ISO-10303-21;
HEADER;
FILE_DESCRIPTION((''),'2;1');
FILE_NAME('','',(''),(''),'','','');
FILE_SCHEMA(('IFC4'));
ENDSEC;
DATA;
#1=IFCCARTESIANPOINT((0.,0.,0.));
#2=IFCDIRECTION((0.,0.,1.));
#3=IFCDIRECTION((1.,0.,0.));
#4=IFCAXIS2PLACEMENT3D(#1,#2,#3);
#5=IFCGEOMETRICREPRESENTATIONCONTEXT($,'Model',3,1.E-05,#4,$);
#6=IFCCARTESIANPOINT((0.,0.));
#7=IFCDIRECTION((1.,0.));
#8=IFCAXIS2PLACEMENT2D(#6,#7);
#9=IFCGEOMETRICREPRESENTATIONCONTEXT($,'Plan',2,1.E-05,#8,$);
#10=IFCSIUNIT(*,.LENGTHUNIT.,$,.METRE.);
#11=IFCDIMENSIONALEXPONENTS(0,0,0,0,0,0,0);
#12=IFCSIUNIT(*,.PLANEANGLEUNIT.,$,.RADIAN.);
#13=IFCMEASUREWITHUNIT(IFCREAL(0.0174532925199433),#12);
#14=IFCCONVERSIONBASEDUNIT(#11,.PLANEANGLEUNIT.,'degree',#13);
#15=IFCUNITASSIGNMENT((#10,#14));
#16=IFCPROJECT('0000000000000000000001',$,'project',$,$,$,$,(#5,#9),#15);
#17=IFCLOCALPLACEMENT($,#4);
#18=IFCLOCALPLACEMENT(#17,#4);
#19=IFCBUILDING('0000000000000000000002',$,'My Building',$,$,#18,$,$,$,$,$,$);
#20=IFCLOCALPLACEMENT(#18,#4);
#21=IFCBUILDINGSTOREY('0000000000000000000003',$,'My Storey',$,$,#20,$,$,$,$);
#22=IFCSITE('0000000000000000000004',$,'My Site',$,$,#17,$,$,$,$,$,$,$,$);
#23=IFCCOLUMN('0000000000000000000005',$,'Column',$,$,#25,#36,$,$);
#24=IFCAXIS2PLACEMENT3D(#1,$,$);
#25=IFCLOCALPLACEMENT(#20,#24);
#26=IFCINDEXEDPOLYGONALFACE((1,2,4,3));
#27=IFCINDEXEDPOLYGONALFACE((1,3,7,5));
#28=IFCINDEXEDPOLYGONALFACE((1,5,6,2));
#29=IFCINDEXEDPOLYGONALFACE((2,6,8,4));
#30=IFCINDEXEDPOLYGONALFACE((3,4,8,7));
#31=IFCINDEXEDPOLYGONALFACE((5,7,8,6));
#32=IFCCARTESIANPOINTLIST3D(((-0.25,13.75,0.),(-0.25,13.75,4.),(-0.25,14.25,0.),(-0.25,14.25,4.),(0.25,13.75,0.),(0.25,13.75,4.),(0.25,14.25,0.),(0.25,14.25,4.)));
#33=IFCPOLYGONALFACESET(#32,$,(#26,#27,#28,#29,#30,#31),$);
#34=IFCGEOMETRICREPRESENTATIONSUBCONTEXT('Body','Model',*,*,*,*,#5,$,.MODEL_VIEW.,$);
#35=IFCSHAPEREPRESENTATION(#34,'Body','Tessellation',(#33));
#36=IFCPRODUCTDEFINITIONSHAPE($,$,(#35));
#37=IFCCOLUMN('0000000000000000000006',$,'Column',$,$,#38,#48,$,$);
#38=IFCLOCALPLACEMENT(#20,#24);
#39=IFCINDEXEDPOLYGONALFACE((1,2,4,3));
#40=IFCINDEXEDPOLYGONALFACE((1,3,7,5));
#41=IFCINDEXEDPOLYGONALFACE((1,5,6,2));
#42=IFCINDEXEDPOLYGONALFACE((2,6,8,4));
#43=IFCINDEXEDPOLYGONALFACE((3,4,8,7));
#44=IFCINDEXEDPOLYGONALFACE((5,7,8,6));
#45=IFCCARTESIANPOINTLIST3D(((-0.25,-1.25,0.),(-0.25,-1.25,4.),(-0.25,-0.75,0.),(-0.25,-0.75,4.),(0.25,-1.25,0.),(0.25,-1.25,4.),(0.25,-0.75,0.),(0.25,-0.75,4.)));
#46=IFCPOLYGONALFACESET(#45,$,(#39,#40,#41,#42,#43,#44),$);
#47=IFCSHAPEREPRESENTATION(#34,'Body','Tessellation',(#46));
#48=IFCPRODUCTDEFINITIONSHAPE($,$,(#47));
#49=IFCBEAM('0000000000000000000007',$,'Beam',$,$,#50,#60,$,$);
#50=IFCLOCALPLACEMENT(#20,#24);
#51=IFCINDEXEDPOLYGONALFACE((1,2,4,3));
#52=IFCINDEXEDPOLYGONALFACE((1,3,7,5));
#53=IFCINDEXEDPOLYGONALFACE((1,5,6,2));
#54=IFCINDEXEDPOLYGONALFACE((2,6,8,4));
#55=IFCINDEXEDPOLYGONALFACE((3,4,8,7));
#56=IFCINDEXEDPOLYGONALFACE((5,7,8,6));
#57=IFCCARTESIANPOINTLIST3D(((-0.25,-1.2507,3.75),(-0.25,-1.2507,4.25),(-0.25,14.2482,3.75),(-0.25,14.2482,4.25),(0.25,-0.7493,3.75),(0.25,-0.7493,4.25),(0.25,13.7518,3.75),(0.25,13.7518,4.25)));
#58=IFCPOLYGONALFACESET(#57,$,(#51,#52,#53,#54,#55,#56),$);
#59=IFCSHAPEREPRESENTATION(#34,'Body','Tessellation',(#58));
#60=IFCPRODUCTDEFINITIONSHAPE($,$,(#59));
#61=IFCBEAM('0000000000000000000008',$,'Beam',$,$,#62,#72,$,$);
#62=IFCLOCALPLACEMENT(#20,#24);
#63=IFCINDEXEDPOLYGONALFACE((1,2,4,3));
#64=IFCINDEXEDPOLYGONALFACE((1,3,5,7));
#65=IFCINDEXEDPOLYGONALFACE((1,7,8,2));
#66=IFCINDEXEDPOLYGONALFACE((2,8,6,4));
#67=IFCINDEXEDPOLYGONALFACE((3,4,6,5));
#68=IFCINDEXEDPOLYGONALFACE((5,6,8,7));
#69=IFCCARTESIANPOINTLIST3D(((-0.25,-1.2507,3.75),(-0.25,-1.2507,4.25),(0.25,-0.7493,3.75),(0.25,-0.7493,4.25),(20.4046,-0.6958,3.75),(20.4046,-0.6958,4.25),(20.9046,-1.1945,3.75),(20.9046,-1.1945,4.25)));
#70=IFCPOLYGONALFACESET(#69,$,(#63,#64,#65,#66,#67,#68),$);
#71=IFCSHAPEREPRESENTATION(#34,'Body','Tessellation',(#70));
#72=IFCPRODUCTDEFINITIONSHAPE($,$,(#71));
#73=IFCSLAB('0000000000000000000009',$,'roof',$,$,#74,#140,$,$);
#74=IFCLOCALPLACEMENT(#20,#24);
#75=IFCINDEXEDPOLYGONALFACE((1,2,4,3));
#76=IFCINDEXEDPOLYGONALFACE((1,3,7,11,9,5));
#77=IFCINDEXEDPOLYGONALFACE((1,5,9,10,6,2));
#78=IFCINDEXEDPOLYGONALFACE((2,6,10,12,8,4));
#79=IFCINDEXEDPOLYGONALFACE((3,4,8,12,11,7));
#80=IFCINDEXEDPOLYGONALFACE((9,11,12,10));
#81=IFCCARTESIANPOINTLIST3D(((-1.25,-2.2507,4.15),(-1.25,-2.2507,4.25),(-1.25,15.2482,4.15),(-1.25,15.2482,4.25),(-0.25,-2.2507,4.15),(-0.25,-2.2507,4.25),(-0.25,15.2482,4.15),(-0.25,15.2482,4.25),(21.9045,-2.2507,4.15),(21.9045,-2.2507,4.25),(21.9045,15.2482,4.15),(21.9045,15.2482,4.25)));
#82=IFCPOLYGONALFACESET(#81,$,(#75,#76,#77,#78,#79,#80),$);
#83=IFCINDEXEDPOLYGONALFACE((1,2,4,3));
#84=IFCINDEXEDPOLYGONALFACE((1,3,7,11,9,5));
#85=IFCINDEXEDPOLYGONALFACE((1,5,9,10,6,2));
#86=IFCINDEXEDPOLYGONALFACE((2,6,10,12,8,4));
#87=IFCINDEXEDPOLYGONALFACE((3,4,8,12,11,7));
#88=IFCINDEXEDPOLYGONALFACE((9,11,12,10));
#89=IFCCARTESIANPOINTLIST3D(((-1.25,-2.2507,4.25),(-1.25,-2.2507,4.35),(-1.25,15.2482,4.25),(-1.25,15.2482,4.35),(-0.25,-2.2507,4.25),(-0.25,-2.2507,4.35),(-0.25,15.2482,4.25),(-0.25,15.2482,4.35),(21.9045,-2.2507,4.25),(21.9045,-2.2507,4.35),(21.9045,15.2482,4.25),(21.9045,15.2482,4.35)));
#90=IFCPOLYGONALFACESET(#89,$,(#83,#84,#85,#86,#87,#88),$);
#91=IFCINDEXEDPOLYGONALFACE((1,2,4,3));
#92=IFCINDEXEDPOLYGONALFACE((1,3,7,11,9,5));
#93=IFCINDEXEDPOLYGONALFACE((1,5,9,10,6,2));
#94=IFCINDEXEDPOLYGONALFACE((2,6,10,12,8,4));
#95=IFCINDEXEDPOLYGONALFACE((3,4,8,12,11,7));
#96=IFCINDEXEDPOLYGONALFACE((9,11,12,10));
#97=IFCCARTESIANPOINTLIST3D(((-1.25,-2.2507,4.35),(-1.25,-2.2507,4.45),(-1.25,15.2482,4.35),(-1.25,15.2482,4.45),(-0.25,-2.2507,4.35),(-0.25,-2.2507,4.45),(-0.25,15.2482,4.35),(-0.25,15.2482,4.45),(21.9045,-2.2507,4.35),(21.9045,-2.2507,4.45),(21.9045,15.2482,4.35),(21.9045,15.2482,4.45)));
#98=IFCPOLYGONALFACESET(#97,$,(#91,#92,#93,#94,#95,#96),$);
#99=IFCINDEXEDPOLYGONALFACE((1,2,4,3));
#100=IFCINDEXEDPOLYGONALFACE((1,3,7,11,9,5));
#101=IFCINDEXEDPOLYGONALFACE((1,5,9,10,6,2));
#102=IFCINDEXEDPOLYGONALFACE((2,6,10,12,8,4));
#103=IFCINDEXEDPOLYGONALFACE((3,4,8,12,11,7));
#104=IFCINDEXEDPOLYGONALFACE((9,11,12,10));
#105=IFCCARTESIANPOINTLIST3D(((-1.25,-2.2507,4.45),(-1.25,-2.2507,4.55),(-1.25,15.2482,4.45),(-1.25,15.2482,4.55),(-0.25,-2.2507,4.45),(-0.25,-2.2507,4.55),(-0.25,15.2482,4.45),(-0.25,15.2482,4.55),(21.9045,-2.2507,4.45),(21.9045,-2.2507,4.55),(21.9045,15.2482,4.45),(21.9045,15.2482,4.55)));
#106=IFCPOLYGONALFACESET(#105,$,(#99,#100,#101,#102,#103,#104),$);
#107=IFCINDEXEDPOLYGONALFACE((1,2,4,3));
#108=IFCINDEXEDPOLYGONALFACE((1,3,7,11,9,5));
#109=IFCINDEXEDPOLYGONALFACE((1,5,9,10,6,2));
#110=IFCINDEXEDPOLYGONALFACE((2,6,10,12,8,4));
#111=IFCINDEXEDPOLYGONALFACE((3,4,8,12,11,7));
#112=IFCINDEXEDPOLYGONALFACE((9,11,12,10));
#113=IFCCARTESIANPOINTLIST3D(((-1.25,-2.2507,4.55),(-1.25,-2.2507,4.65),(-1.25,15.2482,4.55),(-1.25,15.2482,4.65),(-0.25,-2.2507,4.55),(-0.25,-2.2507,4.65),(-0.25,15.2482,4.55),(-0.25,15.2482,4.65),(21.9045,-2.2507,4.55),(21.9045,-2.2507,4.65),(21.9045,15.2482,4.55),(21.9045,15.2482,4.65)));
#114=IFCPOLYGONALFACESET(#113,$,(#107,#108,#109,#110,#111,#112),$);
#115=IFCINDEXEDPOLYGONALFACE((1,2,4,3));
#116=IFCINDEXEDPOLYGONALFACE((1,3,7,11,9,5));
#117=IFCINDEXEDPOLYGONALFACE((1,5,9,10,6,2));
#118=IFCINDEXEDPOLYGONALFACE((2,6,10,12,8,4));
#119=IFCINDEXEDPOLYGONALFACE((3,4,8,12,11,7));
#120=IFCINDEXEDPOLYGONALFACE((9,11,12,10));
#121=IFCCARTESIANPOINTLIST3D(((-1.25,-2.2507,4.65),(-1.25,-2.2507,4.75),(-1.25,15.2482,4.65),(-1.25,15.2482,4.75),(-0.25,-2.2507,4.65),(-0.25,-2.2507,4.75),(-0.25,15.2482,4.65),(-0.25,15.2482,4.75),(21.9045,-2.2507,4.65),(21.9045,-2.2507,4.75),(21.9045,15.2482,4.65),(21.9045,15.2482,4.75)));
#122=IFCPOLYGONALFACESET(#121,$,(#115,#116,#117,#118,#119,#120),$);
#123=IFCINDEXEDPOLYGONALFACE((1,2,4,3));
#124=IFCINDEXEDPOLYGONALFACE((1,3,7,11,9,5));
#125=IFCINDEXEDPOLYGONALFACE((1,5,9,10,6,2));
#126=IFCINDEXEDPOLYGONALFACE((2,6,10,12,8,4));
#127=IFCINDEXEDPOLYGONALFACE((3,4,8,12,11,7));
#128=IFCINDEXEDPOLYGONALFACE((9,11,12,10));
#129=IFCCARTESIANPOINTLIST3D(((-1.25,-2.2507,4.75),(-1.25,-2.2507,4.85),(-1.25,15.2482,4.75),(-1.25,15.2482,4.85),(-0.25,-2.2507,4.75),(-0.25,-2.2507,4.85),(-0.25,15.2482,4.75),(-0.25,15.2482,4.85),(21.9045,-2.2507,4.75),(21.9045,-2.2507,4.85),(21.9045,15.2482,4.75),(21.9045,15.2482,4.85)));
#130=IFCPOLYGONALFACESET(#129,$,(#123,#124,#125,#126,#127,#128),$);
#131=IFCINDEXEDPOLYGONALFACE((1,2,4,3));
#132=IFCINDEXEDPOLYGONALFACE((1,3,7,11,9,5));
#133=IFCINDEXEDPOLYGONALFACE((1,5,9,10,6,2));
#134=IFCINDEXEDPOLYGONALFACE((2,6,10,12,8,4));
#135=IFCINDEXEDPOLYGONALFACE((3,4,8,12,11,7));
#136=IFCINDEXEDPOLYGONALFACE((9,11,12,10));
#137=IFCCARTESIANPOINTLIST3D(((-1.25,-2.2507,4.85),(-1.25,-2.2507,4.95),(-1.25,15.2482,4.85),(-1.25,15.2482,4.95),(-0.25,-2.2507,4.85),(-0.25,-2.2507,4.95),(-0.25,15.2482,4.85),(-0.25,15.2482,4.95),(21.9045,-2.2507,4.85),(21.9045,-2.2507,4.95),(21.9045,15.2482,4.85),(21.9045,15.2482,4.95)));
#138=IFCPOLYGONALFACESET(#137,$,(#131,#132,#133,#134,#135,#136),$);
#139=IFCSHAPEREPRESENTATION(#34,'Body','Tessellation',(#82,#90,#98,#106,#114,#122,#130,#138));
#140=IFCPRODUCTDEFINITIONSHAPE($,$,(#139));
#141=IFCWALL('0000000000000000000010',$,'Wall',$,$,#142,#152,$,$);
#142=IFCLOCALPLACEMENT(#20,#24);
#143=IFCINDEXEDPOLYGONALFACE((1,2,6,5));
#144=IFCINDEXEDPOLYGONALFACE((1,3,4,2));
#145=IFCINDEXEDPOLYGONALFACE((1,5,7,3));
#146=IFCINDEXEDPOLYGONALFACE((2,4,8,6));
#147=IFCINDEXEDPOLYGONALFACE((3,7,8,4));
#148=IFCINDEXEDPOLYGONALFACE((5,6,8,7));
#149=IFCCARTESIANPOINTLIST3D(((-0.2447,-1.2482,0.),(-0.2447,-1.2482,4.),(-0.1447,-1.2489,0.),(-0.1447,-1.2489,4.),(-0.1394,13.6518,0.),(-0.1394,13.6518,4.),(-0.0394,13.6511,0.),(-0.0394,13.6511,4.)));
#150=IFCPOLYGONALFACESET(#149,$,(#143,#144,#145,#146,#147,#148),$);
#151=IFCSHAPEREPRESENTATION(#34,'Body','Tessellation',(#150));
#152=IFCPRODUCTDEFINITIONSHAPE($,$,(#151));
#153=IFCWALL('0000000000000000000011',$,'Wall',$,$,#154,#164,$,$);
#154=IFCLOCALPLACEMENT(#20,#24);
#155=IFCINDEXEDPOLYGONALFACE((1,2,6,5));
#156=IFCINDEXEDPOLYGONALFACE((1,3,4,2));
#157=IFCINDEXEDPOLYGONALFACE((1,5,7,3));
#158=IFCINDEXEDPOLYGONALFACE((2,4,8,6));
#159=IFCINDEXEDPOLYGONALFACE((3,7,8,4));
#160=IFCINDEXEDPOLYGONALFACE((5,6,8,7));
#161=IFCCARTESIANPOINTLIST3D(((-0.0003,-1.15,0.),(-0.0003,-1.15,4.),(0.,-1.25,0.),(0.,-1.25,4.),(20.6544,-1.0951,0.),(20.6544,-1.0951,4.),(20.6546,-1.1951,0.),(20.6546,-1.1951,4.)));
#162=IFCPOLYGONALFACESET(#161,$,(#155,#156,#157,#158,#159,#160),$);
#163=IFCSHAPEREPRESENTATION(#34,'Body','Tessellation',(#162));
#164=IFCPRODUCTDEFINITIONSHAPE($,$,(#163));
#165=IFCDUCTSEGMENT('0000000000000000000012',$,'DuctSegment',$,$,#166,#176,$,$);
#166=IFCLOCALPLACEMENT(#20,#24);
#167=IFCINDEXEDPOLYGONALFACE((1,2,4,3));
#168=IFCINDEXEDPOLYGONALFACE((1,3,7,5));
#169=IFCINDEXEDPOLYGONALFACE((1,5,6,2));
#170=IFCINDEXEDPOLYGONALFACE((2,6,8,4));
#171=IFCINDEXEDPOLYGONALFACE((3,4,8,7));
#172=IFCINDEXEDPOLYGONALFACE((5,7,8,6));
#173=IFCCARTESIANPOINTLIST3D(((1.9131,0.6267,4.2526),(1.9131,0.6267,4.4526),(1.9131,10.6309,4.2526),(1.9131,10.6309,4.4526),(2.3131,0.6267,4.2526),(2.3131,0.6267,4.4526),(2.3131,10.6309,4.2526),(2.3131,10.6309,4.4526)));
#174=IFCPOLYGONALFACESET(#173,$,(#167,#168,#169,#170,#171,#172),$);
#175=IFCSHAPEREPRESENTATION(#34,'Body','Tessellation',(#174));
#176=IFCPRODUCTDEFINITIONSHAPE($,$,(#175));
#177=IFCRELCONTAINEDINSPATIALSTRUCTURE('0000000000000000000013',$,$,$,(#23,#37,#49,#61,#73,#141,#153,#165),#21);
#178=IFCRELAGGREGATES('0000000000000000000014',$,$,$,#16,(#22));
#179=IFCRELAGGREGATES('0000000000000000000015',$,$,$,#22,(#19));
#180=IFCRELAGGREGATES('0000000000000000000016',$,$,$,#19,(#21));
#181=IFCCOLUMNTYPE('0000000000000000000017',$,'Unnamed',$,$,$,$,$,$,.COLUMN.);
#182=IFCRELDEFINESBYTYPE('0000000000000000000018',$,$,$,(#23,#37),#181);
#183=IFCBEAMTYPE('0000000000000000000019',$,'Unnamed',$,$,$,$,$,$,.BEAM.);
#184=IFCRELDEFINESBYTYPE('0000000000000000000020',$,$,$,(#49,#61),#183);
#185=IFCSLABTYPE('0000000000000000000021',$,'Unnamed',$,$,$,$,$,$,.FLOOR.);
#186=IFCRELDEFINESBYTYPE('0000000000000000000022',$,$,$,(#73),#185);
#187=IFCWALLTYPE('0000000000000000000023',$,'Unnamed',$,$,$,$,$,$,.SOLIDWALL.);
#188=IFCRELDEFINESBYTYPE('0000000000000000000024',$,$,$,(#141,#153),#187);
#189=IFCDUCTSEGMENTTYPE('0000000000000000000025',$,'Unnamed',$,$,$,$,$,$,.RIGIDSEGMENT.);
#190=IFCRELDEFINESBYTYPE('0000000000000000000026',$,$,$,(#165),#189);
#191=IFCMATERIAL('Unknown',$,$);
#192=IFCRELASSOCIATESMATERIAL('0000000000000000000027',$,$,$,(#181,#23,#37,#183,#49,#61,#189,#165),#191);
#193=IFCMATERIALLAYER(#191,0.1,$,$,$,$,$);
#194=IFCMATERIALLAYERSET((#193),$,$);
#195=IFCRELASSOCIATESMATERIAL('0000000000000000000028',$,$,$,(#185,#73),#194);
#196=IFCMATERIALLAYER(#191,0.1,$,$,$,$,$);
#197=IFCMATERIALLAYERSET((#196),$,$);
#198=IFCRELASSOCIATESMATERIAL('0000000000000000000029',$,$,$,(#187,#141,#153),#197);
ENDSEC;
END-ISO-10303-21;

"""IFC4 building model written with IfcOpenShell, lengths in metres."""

from ifc_helpers import new_model, entity, si_unit, converted_unit, frame, origin_with_axes, origin_2d_with_axis, place, context, subcontext, project, spatial, line, indexed_curve, rectangle, outline, extrude, clip, halfspace, material, layer, layer_set, layer_usage, material_profile, profile_set, profile_usage, type_object, element, save


model = new_model("IFC4")

# Units and contexts
model_context = context("Model", 3, precision=1e-05, world=origin_with_axes())
plan_context = context("Plan", 2, precision=1e-05, world=origin_2d_with_axis())
body_context = subcontext(model_context, "Body", "Model", "MODEL_VIEW")
ifc_project = project(units=[si_unit("LENGTHUNIT", "METRE"), converted_unit("PLANEANGLEUNIT", "degree", entity("IfcReal", 0.0174532925199433), si_unit("PLANEANGLEUNIT", "RADIAN"), dimensions=[0, 0, 0, 0, 0, 0, 0])], contexts=[model_context, plan_context])

# Site, building, storey
site_placement = place(None, origin_with_axes())
site = spatial("IfcSite", under=ifc_project, at=site_placement, Name="My Site")
building_placement = place(site_placement, origin_with_axes())
building = spatial("IfcBuilding", under=site, at=building_placement, Name="My Building")
storey_placement = place(building_placement, origin_with_axes())
storey = spatial("IfcBuildingStorey", under=building, at=storey_placement, Name="My Storey")

# Columns
ifc_material = material(Name="Unknown")
ifc_material_profile_1 = material_profile(ifc_material, rectangle(XDim=0.5, YDim=0.5))
ifc_profile_set_1 = profile_set([ifc_material_profile_1])
ifc_profile_usage_1 = profile_usage(ifc_profile_set_1, cardinal=5)
column_type = type_object("IfcColumnType", Name="Unnamed", PredefinedType="COLUMN", material=ifc_profile_set_1)
column_1_placement = place(storey_placement, frame((0.0, 14.0, 0.0), z_axis=(0.0, 0.0, 1.0), x_axis=(1.0, 0.0, 0.0)))
element("IfcColumn", 1, at=column_1_placement, inside=storey, type_object=column_type, material=ifc_profile_usage_1, Name="Column", context=body_context, shape_type="SweptSolid", body=[
    extrude(rectangle(XDim=0.5, YDim=0.5), origin_with_axes(), (0.0, 0.0, 1.0), 4.0),
])
ifc_profile_usage_2 = profile_usage(ifc_profile_set_1, cardinal=5)
column_2_placement = place(storey_placement, frame((0.0, -1.0, 0.0), z_axis=(0.0, 0.0, 1.0), x_axis=(1.0, 0.0, 0.0)))
element("IfcColumn", 2, at=column_2_placement, inside=storey, type_object=column_type, material=ifc_profile_usage_2, Name="Column", context=body_context, shape_type="SweptSolid", body=[
    extrude(rectangle(XDim=0.5, YDim=0.5), origin_with_axes(), (0.0, 0.0, 1.0), 4.0),
])

# Beams
ifc_material_profile_2 = material_profile(ifc_material, rectangle(XDim=0.5, YDim=0.5))
ifc_profile_set_2 = profile_set([ifc_material_profile_2])
ifc_profile_usage_3 = profile_usage(ifc_profile_set_2, cardinal=5)
beam_type = type_object("IfcBeamType", Name="Unnamed", PredefinedType="BEAM", material=ifc_profile_set_2)
beam_1_placement = place(storey_placement, frame((0.0, 14.75, 4.0), z_axis=(0.0, -1.0, 0.0), x_axis=(1.0, 0.0, 0.0)))
element("IfcBeam", 3, at=beam_1_placement, inside=storey, type_object=beam_type, material=ifc_profile_usage_3, Name="Beam", context=body_context, shape_type="Clipping", body=[
    clip(clip(extrude(rectangle(XDim=0.5, YDim=0.5), origin_with_axes(), (0.0, 0.0, 1.0), 16.5), halfspace(frame((-0.25, -4.0, 16.0007), z_axis=(0.708045, 0.0, 0.706167), x_axis=(0.0, -1.0, 0.0)), False)), halfspace(frame((-0.25, -4.0, 0.5018), z_axis=(0.704533, 0.0, -0.709671), x_axis=(0.0, -1.0, 0.0)), False)),
])
ifc_profile_usage_4 = profile_usage(ifc_profile_set_2, cardinal=5)
beam_2_placement = place(storey_placement, frame((-0.75, -1.002, 4.0), z_axis=(0.999996, 0.002657, 0.0), x_axis=(-0.002657, 0.999996, 0.0)))
element("IfcBeam", 4, at=beam_2_placement, inside=storey, type_object=beam_type, material=ifc_profile_usage_4, Name="Beam", context=body_context, shape_type="Clipping", body=[
    clip(clip(extrude(rectangle(XDim=0.5, YDim=0.5), origin_with_axes(), (0.0, 0.0, 1.0), 22.1547), halfspace(frame((-0.25, -4.0, 21.654), z_axis=(0.706167, 0.0, 0.708045), x_axis=(0.0, -1.0, 0.0)), False)), halfspace(frame((-0.25, -4.0, 0.4993), z_axis=(0.708046, 0.0, -0.706167), x_axis=(0.0, -1.0, 0.0)), False)),
])

# Slab
ifc_layer_1 = layer(ifc_material, 0.1)
ifc_layer_set_1 = layer_set([ifc_layer_1])
ifc_layer_usage_1 = layer_usage(ifc_layer_set_1, "AXIS3", "POSITIVE", -0.1)
slab_type = type_object("IfcSlabType", Name="Unnamed", PredefinedType="FLOOR", material=ifc_layer_set_1)
slab_placement = place(storey_placement, frame((-0.25, 15.2482, 4.25), z_axis=(0.0, 0.0, 1.0), x_axis=(1.0, 0.0, 0.0)))
element("IfcSlab", 5, at=slab_placement, inside=storey, type_object=slab_type, material=ifc_layer_usage_1, Name="roof", context=body_context, shape_type="SweptSolid", body=[
    extrude(outline(indexed_curve([(0.0, 0.0), (22.1545, 0.0), (22.1545, -17.4989), (0.0, -17.4989), (-1.0, -17.4989), (-1.0, 0.0), (0.0, 0.0)])), frame((0.0, 0.0, -0.1), z_axis=(0.0, 0.0, 1.0), x_axis=(1.0, 0.0, 0.0)), (0.0, 0.0, 1.0), 0.1),
    extrude(outline(indexed_curve([(0.0, 0.0), (22.1545, 0.0), (22.1545, -17.4989), (0.0, -17.4989), (-1.0, -17.4989), (-1.0, 0.0), (0.0, 0.0)])), frame((0.0, 0.0, 0.0), z_axis=(0.0, 0.0, 1.0), x_axis=(1.0, 0.0, 0.0)), (0.0, 0.0, 1.0), 0.1),
    extrude(outline(indexed_curve([(0.0, 0.0), (22.1545, 0.0), (22.1545, -17.4989), (0.0, -17.4989), (-1.0, -17.4989), (-1.0, 0.0), (0.0, 0.0)])), frame((0.0, 0.0, 0.1), z_axis=(0.0, 0.0, 1.0), x_axis=(1.0, 0.0, 0.0)), (0.0, 0.0, 1.0), 0.1),
    extrude(outline(indexed_curve([(0.0, 0.0), (22.1545, 0.0), (22.1545, -17.4989), (0.0, -17.4989), (-1.0, -17.4989), (-1.0, 0.0), (0.0, 0.0)])), frame((0.0, 0.0, 0.2), z_axis=(0.0, 0.0, 1.0), x_axis=(1.0, 0.0, 0.0)), (0.0, 0.0, 1.0), 0.1),
    extrude(outline(indexed_curve([(0.0, 0.0), (22.1545, 0.0), (22.1545, -17.4989), (0.0, -17.4989), (-1.0, -17.4989), (-1.0, 0.0), (0.0, 0.0)])), frame((0.0, 0.0, 0.3), z_axis=(0.0, 0.0, 1.0), x_axis=(1.0, 0.0, 0.0)), (0.0, 0.0, 1.0), 0.1),
    extrude(outline(indexed_curve([(0.0, 0.0), (22.1545, 0.0), (22.1545, -17.4989), (0.0, -17.4989), (-1.0, -17.4989), (-1.0, 0.0), (0.0, 0.0)])), frame((0.0, 0.0, 0.4), z_axis=(0.0, 0.0, 1.0), x_axis=(1.0, 0.0, 0.0)), (0.0, 0.0, 1.0), 0.1),
    extrude(outline(indexed_curve([(0.0, 0.0), (22.1545, 0.0), (22.1545, -17.4989), (0.0, -17.4989), (-1.0, -17.4989), (-1.0, 0.0), (0.0, 0.0)])), frame((0.0, 0.0, 0.5), z_axis=(0.0, 0.0, 1.0), x_axis=(1.0, 0.0, 0.0)), (0.0, 0.0, 1.0), 0.1),
    extrude(outline(indexed_curve([(0.0, 0.0), (22.1545, 0.0), (22.1545, -17.4989), (0.0, -17.4989), (-1.0, -17.4989), (-1.0, 0.0), (0.0, 0.0)])), frame((0.0, 0.0, 0.6), z_axis=(0.0, 0.0, 1.0), x_axis=(1.0, 0.0, 0.0)), (0.0, 0.0, 1.0), 0.1),
])

# Walls
ifc_layer_2 = layer(ifc_material, 0.1)
ifc_layer_set_2 = layer_set([ifc_layer_2])
ifc_layer_usage_2 = layer_usage(ifc_layer_set_2, "AXIS2", "POSITIVE", 0.0)
wall_type = type_object("IfcWallType", Name="Unnamed", PredefinedType="SOLIDWALL", material=ifc_layer_set_2)
wall_1_placement = place(storey_placement, frame((-0.1394, 13.6518, 0.0), z_axis=(0.0, 0.0, 1.0), x_axis=(-0.007068, -0.999975, 0.0)))
element("IfcWall", 6, at=wall_1_placement, inside=storey, type_object=wall_type, material=ifc_layer_usage_2, Name="Wall", context=body_context, shape_type="SweptSolid", body=[
    extrude(outline(indexed_curve([(0.0, 0.0), (0.0, 0.1), (14.9004, 0.1), (14.9004, 0.0)], segments=[line(1, 2, 3, 4, 1)])), origin_with_axes(), (0.0, 0.0, 1.0), 4.0),
])
ifc_layer_usage_3 = layer_usage(ifc_layer_set_2, "AXIS2", "POSITIVE", 0.0)
wall_2_placement = place(storey_placement, frame((0.0, -1.25, 0.0), z_axis=(0.0, 0.0, 1.0), x_axis=(0.999996, 0.002657, 0.0)))
element("IfcWall", 7, at=wall_2_placement, inside=storey, type_object=wall_type, material=ifc_layer_usage_3, Name="Wall", context=body_context, shape_type="SweptSolid", body=[
    extrude(outline(indexed_curve([(0.0, 0.0), (0.0, 0.1), (20.6547, 0.1), (20.6547, 0.0)], segments=[line(1, 2, 3, 4, 1)])), origin_with_axes(), (0.0, 0.0, 1.0), 4.0),
])

# Duct segment
ifc_material_profile_3 = material_profile(ifc_material, rectangle(XDim=0.4, YDim=0.2))
ifc_profile_set_3 = profile_set([ifc_material_profile_3])
ifc_profile_usage_5 = profile_usage(ifc_profile_set_3, cardinal=5)
duct_segment_type = type_object("IfcDuctSegmentType", Name="Unnamed", PredefinedType="RIGIDSEGMENT", material=ifc_profile_set_3)
duct_segment_1_placement = place(storey_placement, frame((2.1131, 10.6309, 4.3526), z_axis=(0.0, -1.0, 0.0), x_axis=(1.0, 0.0, 0.0)))
element("IfcDuctSegment", 8, at=duct_segment_1_placement, inside=storey, type_object=duct_segment_type, material=ifc_profile_usage_5, Name="DuctSegment", context=body_context, shape_type="SweptSolid", body=[
    extrude(rectangle(XDim=0.4, YDim=0.2), origin_with_axes(), (0.0, 0.0, 1.0), 10.0042),
])

save(model, "model.ifc")
